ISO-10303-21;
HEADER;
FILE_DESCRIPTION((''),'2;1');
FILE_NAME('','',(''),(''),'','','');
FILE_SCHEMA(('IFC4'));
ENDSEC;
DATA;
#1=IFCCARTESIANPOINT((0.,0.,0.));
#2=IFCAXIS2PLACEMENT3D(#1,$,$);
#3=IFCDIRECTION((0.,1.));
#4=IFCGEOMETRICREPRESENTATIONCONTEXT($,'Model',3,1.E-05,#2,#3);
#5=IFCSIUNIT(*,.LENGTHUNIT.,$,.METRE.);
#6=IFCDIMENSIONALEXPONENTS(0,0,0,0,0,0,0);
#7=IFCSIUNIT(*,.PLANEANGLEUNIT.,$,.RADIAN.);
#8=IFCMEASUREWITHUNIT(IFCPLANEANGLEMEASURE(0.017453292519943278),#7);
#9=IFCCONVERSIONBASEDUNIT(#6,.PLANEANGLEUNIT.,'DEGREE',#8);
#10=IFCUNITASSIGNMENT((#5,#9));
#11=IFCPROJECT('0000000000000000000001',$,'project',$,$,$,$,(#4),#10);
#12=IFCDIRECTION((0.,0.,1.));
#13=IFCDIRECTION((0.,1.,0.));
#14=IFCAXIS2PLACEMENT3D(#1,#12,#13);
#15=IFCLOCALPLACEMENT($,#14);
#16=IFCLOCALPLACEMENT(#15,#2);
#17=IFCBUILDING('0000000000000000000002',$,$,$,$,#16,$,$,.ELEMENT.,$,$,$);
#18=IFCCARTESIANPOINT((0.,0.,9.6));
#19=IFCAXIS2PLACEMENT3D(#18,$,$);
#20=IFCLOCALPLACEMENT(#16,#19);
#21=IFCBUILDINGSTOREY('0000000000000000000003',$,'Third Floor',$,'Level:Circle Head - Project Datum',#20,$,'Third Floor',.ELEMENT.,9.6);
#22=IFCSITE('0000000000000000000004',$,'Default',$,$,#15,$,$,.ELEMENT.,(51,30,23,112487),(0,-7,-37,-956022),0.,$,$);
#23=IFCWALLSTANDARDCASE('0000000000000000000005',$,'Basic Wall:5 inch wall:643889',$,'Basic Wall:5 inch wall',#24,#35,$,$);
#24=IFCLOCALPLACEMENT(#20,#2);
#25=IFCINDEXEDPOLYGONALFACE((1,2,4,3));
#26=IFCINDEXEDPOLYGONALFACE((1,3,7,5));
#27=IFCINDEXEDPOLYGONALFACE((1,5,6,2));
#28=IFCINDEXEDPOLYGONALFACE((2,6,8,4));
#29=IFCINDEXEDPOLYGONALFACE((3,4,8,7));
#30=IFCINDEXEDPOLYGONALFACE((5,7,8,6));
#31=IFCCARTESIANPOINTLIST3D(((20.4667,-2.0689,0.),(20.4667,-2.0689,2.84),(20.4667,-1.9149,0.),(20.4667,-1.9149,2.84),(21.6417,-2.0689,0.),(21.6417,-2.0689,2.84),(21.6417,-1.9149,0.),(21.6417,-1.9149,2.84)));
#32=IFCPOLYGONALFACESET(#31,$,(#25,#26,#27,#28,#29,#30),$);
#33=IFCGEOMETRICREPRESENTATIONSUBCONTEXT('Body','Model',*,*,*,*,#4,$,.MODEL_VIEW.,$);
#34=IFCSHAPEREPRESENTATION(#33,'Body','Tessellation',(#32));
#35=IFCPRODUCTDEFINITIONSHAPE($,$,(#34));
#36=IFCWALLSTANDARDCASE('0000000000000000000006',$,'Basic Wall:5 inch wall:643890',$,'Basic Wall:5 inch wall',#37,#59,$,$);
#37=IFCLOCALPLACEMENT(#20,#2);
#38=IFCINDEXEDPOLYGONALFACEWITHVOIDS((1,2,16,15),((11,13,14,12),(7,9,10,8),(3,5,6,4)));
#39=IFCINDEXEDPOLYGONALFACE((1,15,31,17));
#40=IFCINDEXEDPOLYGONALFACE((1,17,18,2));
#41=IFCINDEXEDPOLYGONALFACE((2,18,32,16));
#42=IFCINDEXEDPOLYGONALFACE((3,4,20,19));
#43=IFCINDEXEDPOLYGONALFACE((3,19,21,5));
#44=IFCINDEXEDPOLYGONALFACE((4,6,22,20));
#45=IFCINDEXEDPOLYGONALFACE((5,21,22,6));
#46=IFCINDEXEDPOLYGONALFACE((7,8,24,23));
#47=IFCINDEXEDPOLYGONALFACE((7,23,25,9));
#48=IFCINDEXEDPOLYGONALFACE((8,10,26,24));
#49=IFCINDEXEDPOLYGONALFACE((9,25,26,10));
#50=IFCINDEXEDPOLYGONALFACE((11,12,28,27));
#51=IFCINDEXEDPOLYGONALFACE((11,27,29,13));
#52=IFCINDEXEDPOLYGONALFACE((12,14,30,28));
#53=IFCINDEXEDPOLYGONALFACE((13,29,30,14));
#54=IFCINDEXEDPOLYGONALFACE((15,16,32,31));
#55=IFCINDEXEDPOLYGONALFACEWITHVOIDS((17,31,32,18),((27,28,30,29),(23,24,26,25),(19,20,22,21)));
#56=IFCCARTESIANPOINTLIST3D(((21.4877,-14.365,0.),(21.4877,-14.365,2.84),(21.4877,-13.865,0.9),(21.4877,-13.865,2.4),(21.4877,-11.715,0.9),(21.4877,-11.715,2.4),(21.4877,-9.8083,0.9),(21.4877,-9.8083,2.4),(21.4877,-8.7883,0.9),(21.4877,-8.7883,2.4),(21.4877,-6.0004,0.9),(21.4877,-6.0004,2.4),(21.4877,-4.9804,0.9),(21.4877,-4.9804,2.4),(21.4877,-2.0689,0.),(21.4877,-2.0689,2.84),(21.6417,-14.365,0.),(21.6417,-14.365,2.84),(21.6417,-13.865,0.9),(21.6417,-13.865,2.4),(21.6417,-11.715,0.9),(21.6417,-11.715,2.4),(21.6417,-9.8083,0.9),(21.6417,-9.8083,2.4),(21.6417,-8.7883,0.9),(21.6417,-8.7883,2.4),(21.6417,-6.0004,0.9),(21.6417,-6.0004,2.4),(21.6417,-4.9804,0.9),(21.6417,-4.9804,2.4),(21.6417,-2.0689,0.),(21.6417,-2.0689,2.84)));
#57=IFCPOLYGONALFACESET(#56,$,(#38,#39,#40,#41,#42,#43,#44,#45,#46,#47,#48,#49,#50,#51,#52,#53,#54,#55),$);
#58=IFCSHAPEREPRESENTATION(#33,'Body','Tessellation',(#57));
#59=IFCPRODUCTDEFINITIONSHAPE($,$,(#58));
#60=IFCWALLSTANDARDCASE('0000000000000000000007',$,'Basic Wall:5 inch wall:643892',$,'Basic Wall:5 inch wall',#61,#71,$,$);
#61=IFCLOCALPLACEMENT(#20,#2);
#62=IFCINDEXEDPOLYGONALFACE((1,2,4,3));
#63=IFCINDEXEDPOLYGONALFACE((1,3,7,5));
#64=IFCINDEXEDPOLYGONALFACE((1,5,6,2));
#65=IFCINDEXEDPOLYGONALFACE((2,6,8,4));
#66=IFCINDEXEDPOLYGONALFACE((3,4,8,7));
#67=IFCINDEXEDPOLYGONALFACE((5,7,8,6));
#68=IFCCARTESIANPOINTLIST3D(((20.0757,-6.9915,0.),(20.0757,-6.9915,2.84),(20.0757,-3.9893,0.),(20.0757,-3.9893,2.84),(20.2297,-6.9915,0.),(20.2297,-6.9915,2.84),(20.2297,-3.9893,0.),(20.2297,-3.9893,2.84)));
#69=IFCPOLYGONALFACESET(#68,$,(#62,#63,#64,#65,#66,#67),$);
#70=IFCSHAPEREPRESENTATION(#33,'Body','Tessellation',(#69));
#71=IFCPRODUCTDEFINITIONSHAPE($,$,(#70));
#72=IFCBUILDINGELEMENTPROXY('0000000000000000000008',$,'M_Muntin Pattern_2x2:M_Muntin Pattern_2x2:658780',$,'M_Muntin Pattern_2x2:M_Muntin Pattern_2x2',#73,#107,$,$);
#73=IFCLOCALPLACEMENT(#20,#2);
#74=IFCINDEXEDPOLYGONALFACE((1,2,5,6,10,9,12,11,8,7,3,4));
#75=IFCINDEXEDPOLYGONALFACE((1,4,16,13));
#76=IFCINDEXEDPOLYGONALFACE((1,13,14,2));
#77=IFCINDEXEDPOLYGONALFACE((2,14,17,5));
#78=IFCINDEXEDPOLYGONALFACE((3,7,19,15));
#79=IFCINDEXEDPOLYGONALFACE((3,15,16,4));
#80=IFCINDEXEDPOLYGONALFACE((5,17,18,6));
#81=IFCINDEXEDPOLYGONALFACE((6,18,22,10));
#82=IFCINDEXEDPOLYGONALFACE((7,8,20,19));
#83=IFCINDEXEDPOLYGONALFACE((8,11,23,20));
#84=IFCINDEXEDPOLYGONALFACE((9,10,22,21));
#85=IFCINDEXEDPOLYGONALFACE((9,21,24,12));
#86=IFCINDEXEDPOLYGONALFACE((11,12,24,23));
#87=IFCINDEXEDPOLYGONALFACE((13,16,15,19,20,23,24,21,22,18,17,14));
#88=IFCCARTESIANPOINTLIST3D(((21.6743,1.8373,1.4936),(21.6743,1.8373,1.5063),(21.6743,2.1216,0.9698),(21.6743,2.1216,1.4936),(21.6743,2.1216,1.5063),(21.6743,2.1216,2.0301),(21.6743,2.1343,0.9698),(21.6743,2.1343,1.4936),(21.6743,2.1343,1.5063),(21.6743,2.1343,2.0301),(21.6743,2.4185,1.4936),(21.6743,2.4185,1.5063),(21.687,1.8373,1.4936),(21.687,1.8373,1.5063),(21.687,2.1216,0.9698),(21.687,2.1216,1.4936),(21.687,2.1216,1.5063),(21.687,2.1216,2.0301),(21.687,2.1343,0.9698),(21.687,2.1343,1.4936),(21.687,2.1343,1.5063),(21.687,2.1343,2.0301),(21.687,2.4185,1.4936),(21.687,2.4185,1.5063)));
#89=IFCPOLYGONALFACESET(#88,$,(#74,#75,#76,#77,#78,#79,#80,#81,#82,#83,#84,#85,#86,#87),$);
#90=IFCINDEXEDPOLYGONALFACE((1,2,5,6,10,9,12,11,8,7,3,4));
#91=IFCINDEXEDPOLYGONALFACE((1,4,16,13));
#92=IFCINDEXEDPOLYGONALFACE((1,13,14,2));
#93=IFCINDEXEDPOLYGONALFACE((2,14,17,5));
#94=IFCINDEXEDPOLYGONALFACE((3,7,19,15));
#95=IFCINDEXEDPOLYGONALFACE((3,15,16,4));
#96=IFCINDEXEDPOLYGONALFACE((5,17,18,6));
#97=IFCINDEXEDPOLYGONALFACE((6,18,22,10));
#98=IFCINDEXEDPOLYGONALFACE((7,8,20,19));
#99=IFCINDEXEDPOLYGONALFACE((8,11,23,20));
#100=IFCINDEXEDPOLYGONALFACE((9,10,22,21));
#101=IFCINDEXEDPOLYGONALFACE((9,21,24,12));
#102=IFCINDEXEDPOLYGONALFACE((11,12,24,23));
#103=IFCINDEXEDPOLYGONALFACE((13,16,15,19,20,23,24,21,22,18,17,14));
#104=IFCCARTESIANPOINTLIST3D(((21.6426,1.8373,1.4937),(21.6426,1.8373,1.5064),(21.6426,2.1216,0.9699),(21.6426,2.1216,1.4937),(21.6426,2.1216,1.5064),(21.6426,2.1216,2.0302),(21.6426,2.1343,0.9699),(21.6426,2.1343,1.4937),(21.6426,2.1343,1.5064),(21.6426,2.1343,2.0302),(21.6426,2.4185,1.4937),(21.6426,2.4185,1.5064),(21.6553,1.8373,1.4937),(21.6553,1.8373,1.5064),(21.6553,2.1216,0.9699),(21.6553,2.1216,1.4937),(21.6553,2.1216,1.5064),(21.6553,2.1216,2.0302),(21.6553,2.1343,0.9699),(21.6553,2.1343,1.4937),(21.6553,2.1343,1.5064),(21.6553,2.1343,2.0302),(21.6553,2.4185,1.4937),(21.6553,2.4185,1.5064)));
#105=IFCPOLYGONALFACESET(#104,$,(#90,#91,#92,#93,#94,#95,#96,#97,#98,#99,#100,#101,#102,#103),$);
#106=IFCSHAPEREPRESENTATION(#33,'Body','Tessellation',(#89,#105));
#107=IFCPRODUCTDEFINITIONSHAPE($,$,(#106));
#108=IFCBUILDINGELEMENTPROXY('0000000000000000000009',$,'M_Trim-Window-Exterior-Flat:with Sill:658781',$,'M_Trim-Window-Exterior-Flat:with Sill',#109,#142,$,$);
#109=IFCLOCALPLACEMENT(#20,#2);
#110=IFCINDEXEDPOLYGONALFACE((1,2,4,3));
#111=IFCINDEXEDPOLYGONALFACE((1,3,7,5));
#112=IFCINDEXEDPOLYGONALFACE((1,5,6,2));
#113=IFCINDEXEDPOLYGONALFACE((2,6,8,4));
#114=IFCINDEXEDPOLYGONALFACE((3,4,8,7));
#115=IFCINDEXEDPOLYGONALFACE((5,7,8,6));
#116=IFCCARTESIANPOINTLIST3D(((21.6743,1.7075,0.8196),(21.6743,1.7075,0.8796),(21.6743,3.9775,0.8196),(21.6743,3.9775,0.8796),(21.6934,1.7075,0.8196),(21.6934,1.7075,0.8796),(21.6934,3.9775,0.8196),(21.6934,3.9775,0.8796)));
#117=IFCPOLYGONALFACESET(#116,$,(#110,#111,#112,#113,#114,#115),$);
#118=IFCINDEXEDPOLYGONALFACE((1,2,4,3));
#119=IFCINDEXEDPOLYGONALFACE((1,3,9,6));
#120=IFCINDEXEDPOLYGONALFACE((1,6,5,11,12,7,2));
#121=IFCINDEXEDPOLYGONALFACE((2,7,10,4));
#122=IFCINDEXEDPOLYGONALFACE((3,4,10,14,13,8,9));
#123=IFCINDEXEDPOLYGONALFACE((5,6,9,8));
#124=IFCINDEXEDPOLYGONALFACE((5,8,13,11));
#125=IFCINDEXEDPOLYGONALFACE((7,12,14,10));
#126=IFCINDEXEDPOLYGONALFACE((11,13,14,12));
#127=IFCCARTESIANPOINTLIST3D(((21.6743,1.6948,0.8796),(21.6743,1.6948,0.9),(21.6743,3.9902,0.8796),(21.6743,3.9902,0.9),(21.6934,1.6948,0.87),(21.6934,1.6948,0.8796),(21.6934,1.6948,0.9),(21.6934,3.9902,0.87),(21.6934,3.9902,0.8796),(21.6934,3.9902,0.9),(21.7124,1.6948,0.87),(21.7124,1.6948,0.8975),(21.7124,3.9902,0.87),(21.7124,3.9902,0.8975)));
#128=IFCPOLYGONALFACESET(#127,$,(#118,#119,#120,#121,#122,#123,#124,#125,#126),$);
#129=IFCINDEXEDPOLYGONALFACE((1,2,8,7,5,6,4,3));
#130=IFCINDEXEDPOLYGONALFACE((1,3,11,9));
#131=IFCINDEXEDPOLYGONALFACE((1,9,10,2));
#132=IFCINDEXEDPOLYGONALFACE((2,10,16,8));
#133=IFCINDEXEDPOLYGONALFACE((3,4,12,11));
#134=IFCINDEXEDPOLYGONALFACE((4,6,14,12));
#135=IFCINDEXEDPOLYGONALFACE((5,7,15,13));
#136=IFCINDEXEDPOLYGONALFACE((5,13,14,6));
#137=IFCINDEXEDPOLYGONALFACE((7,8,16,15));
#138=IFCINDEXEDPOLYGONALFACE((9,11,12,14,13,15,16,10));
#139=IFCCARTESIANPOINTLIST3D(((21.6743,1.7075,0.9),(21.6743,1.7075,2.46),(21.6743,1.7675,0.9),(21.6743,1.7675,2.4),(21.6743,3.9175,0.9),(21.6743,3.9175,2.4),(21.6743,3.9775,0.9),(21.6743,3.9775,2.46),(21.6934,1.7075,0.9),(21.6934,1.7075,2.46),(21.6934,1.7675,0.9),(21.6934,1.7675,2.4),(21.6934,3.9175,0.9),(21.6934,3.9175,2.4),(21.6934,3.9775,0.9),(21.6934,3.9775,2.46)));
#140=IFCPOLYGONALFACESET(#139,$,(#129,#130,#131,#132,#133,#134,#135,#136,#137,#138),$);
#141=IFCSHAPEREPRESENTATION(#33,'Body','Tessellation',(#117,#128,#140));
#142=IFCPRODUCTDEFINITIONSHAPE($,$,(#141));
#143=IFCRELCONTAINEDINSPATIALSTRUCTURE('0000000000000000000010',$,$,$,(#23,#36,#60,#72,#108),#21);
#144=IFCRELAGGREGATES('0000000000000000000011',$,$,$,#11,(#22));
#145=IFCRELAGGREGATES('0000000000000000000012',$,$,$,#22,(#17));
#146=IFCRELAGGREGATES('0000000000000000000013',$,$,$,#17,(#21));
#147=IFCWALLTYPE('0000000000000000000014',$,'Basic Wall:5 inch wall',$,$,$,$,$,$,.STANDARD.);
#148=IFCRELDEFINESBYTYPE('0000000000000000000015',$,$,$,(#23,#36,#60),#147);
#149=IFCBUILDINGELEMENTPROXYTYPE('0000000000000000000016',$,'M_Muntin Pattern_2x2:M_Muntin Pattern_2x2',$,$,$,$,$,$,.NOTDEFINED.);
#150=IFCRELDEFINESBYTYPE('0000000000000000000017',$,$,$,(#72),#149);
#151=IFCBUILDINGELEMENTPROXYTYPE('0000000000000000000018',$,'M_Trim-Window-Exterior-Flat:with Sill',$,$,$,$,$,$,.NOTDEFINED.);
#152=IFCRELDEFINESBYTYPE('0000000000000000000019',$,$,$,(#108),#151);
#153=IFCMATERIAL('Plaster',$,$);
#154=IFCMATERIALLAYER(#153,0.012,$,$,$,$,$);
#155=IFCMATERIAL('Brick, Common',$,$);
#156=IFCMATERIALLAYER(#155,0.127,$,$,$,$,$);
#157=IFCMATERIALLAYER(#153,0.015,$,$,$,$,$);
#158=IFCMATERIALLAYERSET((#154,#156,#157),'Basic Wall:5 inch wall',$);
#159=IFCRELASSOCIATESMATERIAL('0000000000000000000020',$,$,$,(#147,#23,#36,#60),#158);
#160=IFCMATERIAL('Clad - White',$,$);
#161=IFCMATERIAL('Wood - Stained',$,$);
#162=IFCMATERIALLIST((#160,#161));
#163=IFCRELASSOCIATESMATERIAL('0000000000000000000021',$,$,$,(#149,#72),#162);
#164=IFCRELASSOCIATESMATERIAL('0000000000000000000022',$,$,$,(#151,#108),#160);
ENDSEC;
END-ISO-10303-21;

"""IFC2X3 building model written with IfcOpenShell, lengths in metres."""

from ifc_helpers import new_model, entity, si_unit, converted_unit, direction, frame, frame_2d, origin, place, context, subcontext, project, spatial, polyline, rectangle, outline, extrude, source, transform, mapped, material, material_list, layer, layer_set, layer_usage, type_object, type_shapes, element, save


model = new_model("IFC2X3")

# Units and contexts
model_context = context("Model", 3, precision=1e-05, world=origin(), true_north=direction((0.0, 1.0)))
body_context = subcontext(model_context, "Body", "Model", "MODEL_VIEW")
ifc_project = project(units=[si_unit("LENGTHUNIT", "METRE"), converted_unit("PLANEANGLEUNIT", "DEGREE", entity("IfcPlaneAngleMeasure", 0.017453292519943278), si_unit("PLANEANGLEUNIT", "RADIAN"), dimensions=[0, 0, 0, 0, 0, 0, 0])], contexts=[model_context])

# Site, building, storey
site_placement = place(None, frame((0.0, 0.0, 0.0), z_axis=(0.0, 0.0, 1.0), x_axis=(0.0, 1.0, 0.0)))
site = spatial("IfcSite", under=ifc_project, at=site_placement, Name="Default", CompositionType="ELEMENT", RefLatitude=(51, 30, 23, 112487), RefLongitude=(0, -7, -37, -956022), RefElevation=0.0)
building_placement = place(site_placement, origin())
building = spatial("IfcBuilding", under=site, at=building_placement, CompositionType="ELEMENT")
storey_placement = place(building_placement, frame((0.0, 0.0, 9.6)))
storey = spatial("IfcBuildingStorey", under=building, at=storey_placement, Name="Third Floor", ObjectType="Level:Circle Head - Project Datum", LongName="Third Floor", CompositionType="ELEMENT", Elevation=9.6)

# Shared definitions
ifc_material_1 = material(Name="Plaster")
ifc_layer_1 = layer(ifc_material_1, 0.012)
ifc_material_2 = material(Name="Brick, Common")
ifc_layer_2 = layer(ifc_material_2, 0.127)
ifc_layer_3 = layer(ifc_material_1, 0.015)
ifc_layer_set = layer_set([ifc_layer_1, ifc_layer_2, ifc_layer_3], Name="Basic Wall:5 inch wall")
wall_type = type_object("IfcWallType", Name="Basic Wall:5 inch wall", PredefinedType="STANDARD", material=ifc_layer_set)

# Wall
ifc_layer_usage_1 = layer_usage(ifc_layer_set, "AXIS2", "NEGATIVE", 0.077)
wall_1_placement = place(storey_placement, frame((20.4667, -1.9919, 0.0)))
element("IfcWallStandardCase", 1, at=wall_1_placement, inside=storey, type_object=wall_type, material=ifc_layer_usage_1, Name="Basic Wall:5 inch wall:643889", ObjectType="Basic Wall:5 inch wall", context=body_context, shape_type="SweptSolid", body=[
    extrude(rectangle(XDim=1.175, YDim=0.154, at=frame_2d((0.5875, 0.0), x_axis=(-1.0, 0.0))), origin(), (0.0, 0.0, 1.0), 2.84),
])

# Wall, openings
ifc_layer_usage_2 = layer_usage(ifc_layer_set, "AXIS2", "NEGATIVE", 0.077)
wall_2_placement = place(storey_placement, frame((21.5647, -2.0689, 0.0), z_axis=(0.0, 0.0, 1.0), x_axis=(0.0, -1.0, 0.0)))
wall_2 = element("IfcWallStandardCase", 2, at=wall_2_placement, inside=storey, type_object=wall_type, material=ifc_layer_usage_2, Name="Basic Wall:5 inch wall:643890", ObjectType="Basic Wall:5 inch wall", context=body_context, shape_type="SweptSolid", body=[
    extrude(rectangle(XDim=12.2961, YDim=0.154, at=frame_2d((6.1481, 0.0), x_axis=(-1.0, 0.0))), origin(), (0.0, 0.0, 1.0), 2.84),
])
opening_1_placement = place(wall_2_placement, frame((9.6461, -0.077, 0.9)))
element("IfcOpeningElement", 3, at=opening_1_placement, cuts=wall_2, ObjectType="Opening", context=body_context, shape_type="SweptSolid", body=[
    extrude(rectangle(XDim=1.5, YDim=2.15, at=frame_2d((0.75, 1.075), x_axis=(-1.0, 0.0))), frame((0.0, 0.0, 0.0), z_axis=(0.0, 1.0, 0.0), x_axis=(0.0, 0.0, 1.0)), (0.0, 0.0, 1.0), 0.154),
])
opening_2_placement = place(wall_2_placement, frame((6.7194, -0.077, 0.9)))
element("IfcOpeningElement", 4, at=opening_2_placement, cuts=wall_2, ObjectType="Opening", context=body_context, shape_type="SweptSolid", body=[
    extrude(rectangle(XDim=1.5, YDim=1.02, at=frame_2d((0.75, 0.51), x_axis=(-1.0, 0.0))), frame((0.0, 0.0, 0.0), z_axis=(0.0, 1.0, 0.0), x_axis=(0.0, 0.0, 1.0)), (0.0, 0.0, 1.0), 0.154),
])
opening_3_placement = place(wall_2_placement, frame((2.9115, -0.077, 0.9)))
element("IfcOpeningElement", 5, at=opening_3_placement, cuts=wall_2, ObjectType="Opening", context=body_context, shape_type="SweptSolid", body=[
    extrude(rectangle(XDim=1.5, YDim=1.02, at=frame_2d((0.75, 0.51), x_axis=(-1.0, 0.0))), frame((0.0, 0.0, 0.0), z_axis=(0.0, 1.0, 0.0), x_axis=(0.0, 0.0, 1.0)), (0.0, 0.0, 1.0), 0.154),
])

# Wall
ifc_layer_usage_3 = layer_usage(ifc_layer_set, "AXIS2", "NEGATIVE", 0.077)
wall_3_placement = place(storey_placement, frame((20.1527, -3.9893, 0.0), z_axis=(0.0, 0.0, 1.0), x_axis=(0.0, -1.0, 0.0)))
element("IfcWallStandardCase", 6, at=wall_3_placement, inside=storey, type_object=wall_type, material=ifc_layer_usage_3, Name="Basic Wall:5 inch wall:643892", ObjectType="Basic Wall:5 inch wall", context=body_context, shape_type="SweptSolid", body=[
    extrude(rectangle(XDim=3.0022, YDim=0.154, at=frame_2d((1.5011, 0.0), x_axis=(-1.0, 0.0))), origin(), (0.0, 0.0, 1.0), 2.84),
])

# Building element proxies
ifc_material_3 = material(Name="Clad - White")
ifc_material_4 = material(Name="Wood - Stained")
ifc_material_list = material_list([ifc_material_3, ifc_material_4])
building_element_proxy_type_1 = type_object("IfcBuildingElementProxyType", Name="M_Muntin Pattern_2x2:M_Muntin Pattern_2x2", PredefinedType="NOTDEFINED", material=ifc_material_list)
shared_shape_1 = source(origin(), body_context, "Body", "SweptSolid", [
    extrude(outline(polyline([(0.0064, -0.0064), (0.5301, -0.0064), (0.5301, 0.0063), (0.0064, 0.0063), (0.0064, 0.2906), (-0.0063, 0.2906), (-0.0063, 0.0063), (-0.5302, 0.0063), (-0.5302, -0.0064), (-0.0063, -0.0064), (-0.0063, -0.2906), (0.0064, -0.2906), (0.0064, -0.0064)])), frame((0.0, -0.0222, 0.5301), z_axis=(0.0, 1.0, 0.0), x_axis=(0.0, 0.0, 1.0)), (0.0, 0.0, 1.0), 0.0127),
    extrude(outline(polyline([(0.0064, -0.0064), (0.5302, -0.0064), (0.5302, 0.0063), (0.0064, 0.0063), (0.0064, 0.2906), (-0.0063, 0.2906), (-0.0063, 0.0063), (-0.5302, 0.0063), (-0.5302, -0.0064), (-0.0063, -0.0064), (-0.0063, -0.2906), (0.0064, -0.2906), (0.0064, -0.0064)])), frame((0.0, 0.0095, 0.5302), z_axis=(0.0, 1.0, 0.0), x_axis=(0.0, 0.0, 1.0)), (0.0, 0.0, 1.0), 0.0127),
])
type_shapes(building_element_proxy_type_1, [shared_shape_1])
proxy_1_placement = place(storey_placement, frame((21.6648, 2.1279, 0.9699), z_axis=(0.0, 0.0, 1.0), x_axis=(0.0, 1.0, 0.0)))
element("IfcBuildingElementProxy", 7, at=proxy_1_placement, inside=storey, type_object=building_element_proxy_type_1, material=ifc_material_list, Name="M_Muntin Pattern_2x2:M_Muntin Pattern_2x2:658780", ObjectType="M_Muntin Pattern_2x2:M_Muntin Pattern_2x2", context=body_context, shape_type="MappedRepresentation", body=[
    mapped(shared_shape_1, transform((0.0, 0.0, 0.0), scale=1.0)),
])
building_element_proxy_type_2 = type_object("IfcBuildingElementProxyType", Name="M_Trim-Window-Exterior-Flat:with Sill", PredefinedType="NOTDEFINED", material=ifc_material_3)
shared_shape_2 = source(origin(), body_context, "Body", "SweptSolid", [
    extrude(rectangle(XDim=2.27, YDim=0.06, at=frame_2d((0.0, 0.0), x_axis=(1.0, 0.0))), frame((0.0, -1.5504, 0.0), z_axis=(0.0, 0.0, 1.0), x_axis=(-1.0, 0.0, 0.0)), (0.0, 0.0, 1.0), 0.019),
    extrude(outline(polyline([(-0.019, -0.0152), (0.0, -0.0152), (0.0, -0.0057), (0.019, -0.0057), (0.019, 0.0148), (0.0, 0.0148), (-0.019, 0.0123), (-0.019, -0.0152)])), frame((-1.1477, -1.5148, 0.019), z_axis=(1.0, 0.0, 0.0), x_axis=(0.0, 0.0, -1.0)), (0.0, 0.0, 1.0), 2.2954),
    extrude(outline(polyline([(-0.795, -1.135), (0.765, -1.135), (0.765, -1.075), (-0.735, -1.075), (-0.735, 1.075), (0.765, 1.075), (0.765, 1.135), (-0.795, 1.135), (-0.795, -1.135)])), frame((0.0, -0.735, 0.0), z_axis=(0.0, 0.0, 1.0), x_axis=(0.0, -1.0, 0.0)), (0.0, 0.0, 1.0), 0.019),
])
type_shapes(building_element_proxy_type_2, [shared_shape_2])
proxy_2_placement = place(storey_placement, frame((21.6743, 2.8425, 2.4), z_axis=(1.0, 0.0, 0.0), x_axis=(0.0, 1.0, 0.0)))
element("IfcBuildingElementProxy", 8, at=proxy_2_placement, inside=storey, type_object=building_element_proxy_type_2, material=ifc_material_3, Name="M_Trim-Window-Exterior-Flat:with Sill:658781", ObjectType="M_Trim-Window-Exterior-Flat:with Sill", context=body_context, shape_type="MappedRepresentation", body=[
    mapped(shared_shape_2, transform((0.0, 0.0, 0.0), scale=1.0)),
])

save(model, "model.ifc")
